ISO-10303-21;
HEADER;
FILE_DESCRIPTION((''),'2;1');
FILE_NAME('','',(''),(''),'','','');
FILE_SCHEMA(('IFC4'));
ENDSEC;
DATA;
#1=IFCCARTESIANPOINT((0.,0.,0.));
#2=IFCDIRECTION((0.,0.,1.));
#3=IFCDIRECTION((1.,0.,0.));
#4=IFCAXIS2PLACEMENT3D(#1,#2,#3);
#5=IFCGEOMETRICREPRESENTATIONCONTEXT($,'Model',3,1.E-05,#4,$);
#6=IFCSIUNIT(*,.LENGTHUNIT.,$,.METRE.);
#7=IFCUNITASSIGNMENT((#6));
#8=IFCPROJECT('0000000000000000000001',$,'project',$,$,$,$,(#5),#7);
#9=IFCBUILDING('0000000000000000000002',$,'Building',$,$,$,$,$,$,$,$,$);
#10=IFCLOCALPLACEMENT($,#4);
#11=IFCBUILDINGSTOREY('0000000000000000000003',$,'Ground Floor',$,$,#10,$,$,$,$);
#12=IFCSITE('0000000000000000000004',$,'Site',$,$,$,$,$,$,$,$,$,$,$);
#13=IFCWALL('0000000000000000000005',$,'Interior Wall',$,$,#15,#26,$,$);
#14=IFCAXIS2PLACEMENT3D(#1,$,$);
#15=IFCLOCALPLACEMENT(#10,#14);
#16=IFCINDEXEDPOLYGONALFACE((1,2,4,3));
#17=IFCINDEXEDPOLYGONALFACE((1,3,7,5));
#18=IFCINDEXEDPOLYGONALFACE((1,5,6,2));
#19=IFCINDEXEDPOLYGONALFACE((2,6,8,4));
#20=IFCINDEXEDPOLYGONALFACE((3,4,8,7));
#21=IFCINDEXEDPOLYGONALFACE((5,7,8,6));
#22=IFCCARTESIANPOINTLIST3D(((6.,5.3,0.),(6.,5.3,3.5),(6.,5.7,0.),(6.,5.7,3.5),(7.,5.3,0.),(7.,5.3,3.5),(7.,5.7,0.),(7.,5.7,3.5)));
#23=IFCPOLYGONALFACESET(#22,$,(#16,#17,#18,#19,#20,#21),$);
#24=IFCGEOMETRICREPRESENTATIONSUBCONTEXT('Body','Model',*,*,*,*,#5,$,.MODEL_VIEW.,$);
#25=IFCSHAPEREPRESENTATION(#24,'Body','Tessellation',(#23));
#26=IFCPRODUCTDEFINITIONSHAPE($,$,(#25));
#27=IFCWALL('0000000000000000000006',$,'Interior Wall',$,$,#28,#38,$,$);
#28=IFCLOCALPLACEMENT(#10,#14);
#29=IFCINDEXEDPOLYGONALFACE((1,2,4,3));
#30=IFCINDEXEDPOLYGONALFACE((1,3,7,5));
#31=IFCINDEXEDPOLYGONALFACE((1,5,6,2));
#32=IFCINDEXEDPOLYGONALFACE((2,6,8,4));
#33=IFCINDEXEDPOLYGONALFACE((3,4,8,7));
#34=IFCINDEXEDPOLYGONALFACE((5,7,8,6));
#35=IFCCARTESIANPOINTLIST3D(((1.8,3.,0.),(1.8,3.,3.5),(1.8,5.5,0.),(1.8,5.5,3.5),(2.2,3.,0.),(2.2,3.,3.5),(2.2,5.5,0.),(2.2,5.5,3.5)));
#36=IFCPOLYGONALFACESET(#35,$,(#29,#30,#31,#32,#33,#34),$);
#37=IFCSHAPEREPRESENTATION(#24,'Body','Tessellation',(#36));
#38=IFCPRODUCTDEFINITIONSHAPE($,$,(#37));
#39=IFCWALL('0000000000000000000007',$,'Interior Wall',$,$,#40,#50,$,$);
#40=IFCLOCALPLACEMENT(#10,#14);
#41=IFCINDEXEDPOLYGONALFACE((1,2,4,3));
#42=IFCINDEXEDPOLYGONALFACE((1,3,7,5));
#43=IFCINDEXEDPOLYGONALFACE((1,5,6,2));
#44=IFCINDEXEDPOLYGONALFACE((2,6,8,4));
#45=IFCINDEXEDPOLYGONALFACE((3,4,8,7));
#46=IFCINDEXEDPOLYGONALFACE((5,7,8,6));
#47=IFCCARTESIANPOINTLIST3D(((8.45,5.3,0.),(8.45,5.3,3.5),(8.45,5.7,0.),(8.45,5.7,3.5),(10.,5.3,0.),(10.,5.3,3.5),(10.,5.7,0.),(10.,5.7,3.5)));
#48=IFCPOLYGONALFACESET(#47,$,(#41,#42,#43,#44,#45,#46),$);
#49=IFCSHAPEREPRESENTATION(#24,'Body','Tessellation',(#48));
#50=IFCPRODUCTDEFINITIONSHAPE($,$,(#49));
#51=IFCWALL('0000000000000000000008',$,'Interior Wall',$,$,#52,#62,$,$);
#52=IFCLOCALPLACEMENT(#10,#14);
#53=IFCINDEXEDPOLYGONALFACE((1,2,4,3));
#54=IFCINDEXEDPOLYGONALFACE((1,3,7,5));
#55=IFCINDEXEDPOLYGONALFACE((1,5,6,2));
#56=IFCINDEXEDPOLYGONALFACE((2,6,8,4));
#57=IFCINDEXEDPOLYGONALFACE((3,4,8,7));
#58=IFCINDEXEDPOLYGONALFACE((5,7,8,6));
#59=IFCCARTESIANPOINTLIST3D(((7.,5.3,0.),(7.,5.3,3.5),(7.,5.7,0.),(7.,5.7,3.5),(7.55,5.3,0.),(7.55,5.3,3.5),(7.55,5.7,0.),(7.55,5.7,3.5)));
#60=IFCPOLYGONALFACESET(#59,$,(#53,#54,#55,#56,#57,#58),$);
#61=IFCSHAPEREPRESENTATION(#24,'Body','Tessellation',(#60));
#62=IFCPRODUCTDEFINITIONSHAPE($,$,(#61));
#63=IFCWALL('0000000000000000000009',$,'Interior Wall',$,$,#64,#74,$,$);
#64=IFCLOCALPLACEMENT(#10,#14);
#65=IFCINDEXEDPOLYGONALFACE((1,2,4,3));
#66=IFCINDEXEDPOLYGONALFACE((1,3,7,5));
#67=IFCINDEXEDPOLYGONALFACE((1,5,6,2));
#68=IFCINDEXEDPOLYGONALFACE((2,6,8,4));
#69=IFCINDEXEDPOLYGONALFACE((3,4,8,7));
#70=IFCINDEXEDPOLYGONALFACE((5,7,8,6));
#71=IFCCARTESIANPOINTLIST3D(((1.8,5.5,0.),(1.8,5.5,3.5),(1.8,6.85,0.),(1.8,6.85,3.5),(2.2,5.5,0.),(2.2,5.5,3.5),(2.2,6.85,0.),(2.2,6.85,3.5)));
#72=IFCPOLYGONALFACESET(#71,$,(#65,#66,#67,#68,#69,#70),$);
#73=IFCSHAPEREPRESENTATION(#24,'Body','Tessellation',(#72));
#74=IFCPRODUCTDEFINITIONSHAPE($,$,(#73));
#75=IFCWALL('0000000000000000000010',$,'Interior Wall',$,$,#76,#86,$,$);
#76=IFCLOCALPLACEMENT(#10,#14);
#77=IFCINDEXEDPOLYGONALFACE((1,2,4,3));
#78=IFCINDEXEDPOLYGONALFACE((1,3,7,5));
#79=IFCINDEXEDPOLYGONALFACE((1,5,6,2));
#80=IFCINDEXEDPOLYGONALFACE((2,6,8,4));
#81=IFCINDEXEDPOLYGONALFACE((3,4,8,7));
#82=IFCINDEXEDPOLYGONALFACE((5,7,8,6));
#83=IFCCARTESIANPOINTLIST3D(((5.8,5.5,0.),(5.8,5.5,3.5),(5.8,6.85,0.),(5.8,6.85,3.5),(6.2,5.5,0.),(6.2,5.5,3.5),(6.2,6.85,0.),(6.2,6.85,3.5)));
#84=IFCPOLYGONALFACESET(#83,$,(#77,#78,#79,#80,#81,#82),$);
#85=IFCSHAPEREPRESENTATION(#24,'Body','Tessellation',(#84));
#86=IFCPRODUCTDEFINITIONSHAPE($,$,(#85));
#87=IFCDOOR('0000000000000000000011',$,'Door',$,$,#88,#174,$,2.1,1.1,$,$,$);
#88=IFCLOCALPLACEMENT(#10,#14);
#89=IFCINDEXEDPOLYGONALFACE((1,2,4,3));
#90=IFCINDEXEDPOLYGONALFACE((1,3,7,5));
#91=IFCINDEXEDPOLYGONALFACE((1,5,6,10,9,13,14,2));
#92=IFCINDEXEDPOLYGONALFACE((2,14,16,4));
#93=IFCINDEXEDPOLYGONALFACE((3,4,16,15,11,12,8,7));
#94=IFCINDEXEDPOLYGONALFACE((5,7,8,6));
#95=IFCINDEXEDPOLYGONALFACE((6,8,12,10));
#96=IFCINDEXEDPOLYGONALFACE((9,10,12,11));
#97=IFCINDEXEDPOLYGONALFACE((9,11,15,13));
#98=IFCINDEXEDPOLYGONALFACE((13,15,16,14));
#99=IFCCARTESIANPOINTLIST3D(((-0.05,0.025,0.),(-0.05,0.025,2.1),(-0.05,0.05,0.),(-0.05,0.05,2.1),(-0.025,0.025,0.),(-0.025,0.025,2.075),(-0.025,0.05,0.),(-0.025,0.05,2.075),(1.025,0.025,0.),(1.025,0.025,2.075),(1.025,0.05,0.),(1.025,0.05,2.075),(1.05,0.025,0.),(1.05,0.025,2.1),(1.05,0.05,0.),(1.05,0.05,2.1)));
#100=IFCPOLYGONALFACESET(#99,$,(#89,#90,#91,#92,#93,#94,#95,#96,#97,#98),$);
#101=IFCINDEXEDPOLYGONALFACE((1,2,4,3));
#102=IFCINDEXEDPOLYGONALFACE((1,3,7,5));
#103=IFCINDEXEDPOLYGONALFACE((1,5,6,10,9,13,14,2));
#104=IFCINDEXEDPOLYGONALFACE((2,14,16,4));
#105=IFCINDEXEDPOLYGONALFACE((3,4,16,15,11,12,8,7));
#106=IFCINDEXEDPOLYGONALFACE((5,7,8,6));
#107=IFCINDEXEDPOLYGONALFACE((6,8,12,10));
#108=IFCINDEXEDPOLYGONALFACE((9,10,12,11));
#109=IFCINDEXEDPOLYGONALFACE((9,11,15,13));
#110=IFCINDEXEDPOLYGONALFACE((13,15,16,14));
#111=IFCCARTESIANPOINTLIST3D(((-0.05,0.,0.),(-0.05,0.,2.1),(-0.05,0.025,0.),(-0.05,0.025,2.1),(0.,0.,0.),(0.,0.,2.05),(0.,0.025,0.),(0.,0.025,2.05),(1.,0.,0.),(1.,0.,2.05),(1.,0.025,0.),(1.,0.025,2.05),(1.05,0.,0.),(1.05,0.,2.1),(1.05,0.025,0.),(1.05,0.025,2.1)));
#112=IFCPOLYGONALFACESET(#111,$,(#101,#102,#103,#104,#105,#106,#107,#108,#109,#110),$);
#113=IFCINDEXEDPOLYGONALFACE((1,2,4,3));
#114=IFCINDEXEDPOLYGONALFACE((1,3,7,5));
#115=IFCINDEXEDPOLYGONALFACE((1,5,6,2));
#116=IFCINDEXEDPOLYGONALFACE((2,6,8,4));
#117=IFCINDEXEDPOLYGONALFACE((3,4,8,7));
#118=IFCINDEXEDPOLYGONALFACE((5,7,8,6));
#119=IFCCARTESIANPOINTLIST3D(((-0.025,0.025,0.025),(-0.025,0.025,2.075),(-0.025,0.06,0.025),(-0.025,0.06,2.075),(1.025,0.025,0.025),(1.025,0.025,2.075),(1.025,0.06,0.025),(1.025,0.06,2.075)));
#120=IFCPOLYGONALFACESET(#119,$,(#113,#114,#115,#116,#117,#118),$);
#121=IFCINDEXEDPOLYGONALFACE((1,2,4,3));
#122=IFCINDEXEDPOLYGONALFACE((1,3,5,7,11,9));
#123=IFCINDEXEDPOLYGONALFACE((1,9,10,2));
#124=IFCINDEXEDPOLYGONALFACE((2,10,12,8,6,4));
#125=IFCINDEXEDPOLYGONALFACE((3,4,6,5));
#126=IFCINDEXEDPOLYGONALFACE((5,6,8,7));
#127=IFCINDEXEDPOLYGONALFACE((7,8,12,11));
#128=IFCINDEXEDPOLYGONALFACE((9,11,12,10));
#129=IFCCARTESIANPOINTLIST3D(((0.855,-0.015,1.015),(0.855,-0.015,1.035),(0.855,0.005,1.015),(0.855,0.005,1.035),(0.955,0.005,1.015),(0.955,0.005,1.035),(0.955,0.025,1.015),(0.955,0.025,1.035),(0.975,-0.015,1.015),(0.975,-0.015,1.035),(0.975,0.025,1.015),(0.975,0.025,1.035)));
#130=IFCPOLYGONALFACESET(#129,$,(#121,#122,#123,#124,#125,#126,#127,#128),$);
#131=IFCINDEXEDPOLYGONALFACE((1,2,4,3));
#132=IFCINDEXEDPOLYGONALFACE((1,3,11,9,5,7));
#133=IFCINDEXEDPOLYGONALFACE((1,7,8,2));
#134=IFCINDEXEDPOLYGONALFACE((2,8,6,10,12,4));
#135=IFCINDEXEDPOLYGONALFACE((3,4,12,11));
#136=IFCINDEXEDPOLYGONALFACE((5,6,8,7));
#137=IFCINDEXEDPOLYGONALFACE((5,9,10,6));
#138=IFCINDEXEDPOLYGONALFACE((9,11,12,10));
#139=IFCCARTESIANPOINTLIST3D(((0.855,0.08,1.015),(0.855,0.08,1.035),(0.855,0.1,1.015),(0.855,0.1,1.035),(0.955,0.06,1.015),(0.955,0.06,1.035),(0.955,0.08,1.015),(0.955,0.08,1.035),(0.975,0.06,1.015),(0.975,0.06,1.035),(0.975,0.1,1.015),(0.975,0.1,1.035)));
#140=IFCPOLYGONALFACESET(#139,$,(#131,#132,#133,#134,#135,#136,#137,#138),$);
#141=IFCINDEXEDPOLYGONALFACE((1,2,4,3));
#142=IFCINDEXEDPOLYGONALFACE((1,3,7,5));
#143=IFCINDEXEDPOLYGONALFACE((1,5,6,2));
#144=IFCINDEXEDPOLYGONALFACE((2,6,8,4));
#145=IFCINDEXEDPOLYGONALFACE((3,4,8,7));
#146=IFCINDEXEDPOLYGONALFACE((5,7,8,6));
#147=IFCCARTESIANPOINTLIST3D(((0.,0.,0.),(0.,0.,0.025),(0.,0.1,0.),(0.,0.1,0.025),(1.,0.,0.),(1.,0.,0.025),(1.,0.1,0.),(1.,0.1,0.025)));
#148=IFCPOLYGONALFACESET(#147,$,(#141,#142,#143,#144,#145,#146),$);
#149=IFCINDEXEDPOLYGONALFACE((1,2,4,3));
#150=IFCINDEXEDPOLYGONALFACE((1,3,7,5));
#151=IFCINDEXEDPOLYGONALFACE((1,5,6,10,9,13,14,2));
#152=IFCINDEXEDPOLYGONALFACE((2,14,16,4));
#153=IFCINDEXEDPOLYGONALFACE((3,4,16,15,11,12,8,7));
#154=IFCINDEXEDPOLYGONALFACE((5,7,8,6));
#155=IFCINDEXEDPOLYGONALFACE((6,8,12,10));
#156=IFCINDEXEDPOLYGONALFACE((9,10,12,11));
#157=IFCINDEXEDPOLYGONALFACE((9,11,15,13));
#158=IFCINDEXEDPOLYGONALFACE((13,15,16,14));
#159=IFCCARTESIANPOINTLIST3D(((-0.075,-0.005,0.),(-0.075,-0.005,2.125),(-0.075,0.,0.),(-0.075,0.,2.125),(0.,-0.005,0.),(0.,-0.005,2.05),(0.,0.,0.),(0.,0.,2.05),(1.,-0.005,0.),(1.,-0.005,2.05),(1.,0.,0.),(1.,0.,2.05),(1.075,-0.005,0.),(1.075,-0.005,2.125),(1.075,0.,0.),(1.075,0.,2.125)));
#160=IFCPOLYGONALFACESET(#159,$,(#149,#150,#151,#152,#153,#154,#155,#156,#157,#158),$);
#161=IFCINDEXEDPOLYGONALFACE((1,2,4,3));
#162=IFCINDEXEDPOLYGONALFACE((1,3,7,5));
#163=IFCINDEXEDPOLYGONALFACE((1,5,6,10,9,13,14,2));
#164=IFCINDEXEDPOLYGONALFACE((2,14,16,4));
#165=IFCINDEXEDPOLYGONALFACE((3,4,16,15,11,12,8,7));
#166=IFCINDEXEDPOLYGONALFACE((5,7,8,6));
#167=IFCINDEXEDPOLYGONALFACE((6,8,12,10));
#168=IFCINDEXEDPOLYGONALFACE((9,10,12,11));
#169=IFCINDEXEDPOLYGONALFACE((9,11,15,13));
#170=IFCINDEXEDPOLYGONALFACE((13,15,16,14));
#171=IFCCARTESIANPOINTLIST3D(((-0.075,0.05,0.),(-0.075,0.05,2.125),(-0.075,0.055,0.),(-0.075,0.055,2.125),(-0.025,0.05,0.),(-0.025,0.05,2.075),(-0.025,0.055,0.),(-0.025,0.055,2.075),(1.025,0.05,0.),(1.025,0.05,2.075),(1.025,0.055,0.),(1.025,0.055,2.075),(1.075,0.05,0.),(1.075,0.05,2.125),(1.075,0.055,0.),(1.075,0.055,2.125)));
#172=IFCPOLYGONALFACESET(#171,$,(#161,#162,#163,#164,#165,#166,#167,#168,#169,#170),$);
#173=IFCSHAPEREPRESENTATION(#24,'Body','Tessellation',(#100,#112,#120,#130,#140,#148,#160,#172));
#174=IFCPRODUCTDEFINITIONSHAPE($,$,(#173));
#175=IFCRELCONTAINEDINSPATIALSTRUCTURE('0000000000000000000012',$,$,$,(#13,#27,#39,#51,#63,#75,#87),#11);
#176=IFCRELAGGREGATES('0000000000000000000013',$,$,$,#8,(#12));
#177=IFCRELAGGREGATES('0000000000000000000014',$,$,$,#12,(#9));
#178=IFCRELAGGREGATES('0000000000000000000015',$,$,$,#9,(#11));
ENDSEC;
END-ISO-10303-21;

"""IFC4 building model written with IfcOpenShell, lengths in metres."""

from ifc_helpers import new_model, si_unit, frame, origin_with_axes, place, context, subcontext, project, spatial, line, indexed_curve, outline, extrude, element, save


model = new_model("IFC4")

# Units and contexts
model_context = context("Model", 3, precision=1e-05, world=origin_with_axes())
body_context = subcontext(model_context, "Body", "Model", "MODEL_VIEW")
ifc_project = project(units=[si_unit("LENGTHUNIT", "METRE")], contexts=[model_context])

# Site, building, storey
site = spatial("IfcSite", under=ifc_project, Name="Site")
building = spatial("IfcBuilding", under=site, Name="Building")
storey_placement = place(None, origin_with_axes())
storey = spatial("IfcBuildingStorey", under=building, at=storey_placement, Name="Ground Floor")

# Walls
wall_1_placement = place(storey_placement, frame((7.0, 5.5, 0.0), z_axis=(0.0, 0.0, 1.0), x_axis=(-1.0, 0.0, 0.0)))
element("IfcWall", 1, at=wall_1_placement, inside=storey, Name="Interior Wall", context=body_context, shape_type="SweptSolid", body=[
    extrude(outline(indexed_curve([(0.0, 0.0), (0.0, 0.4), (1.0, 0.4), (1.0, 0.0), (0.0, 0.0)], self_intersect=False)), frame((0.0, -0.2, 0.0), z_axis=(0.0, 0.0, 1.0), x_axis=(1.0, 0.0, 0.0)), (0.0, 0.0, 1.0), 3.5),
])
wall_2_placement = place(storey_placement, frame((2.0, 5.5, 0.0), z_axis=(0.0, 0.0, 1.0), x_axis=(0.0, -1.0, 0.0)))
element("IfcWall", 2, at=wall_2_placement, inside=storey, Name="Interior Wall", context=body_context, shape_type="SweptSolid", body=[
    extrude(outline(indexed_curve([(0.0, 0.0), (0.0, 0.4), (2.5, 0.4), (2.5, 0.0), (0.0, 0.0)], self_intersect=False)), frame((0.0, -0.2, 0.0), z_axis=(0.0, 0.0, 1.0), x_axis=(1.0, 0.0, 0.0)), (0.0, 0.0, 1.0), 3.5),
])
wall_3_placement = place(storey_placement, frame((10.0, 5.5, 0.0), z_axis=(0.0, 0.0, 1.0), x_axis=(-1.0, 0.0, 0.0)))
element("IfcWall", 3, at=wall_3_placement, inside=storey, Name="Interior Wall", context=body_context, shape_type="SweptSolid", body=[
    extrude(outline(indexed_curve([(0.0, 0.0), (0.0, 0.4), (1.55, 0.4), (1.55, 0.0), (0.0, 0.0)], self_intersect=False)), frame((0.0, -0.2, 0.0), z_axis=(0.0, 0.0, 1.0), x_axis=(1.0, 0.0, 0.0)), (0.0, 0.0, 1.0), 3.5),
])
wall_4_placement = place(storey_placement, frame((7.55, 5.5, 0.0), z_axis=(0.0, 0.0, 1.0), x_axis=(-1.0, 0.0, 0.0)))
element("IfcWall", 4, at=wall_4_placement, inside=storey, Name="Interior Wall", context=body_context, shape_type="SweptSolid", body=[
    extrude(outline(indexed_curve([(0.0, 0.0), (0.0, 0.4), (0.55, 0.4), (0.55, 0.0), (0.0, 0.0)], self_intersect=False)), frame((0.0, -0.2, 0.0), z_axis=(0.0, 0.0, 1.0), x_axis=(1.0, 0.0, 0.0)), (0.0, 0.0, 1.0), 3.5),
])
for number, where, z_axis, x_axis, name in (
    (5, (2.0, 5.5, 0.0), (0.0, 0.0, 1.0), (0.0, 1.0, 0.0), "Interior Wall"),
    (6, (6.0, 5.5, 0.0), (0.0, 0.0, 1.0), (0.0, 1.0, 0.0), "Interior Wall"),
):
    element("IfcWall", number, at=place(storey_placement, frame(where, z_axis=z_axis, x_axis=x_axis)), inside=storey, Name=name, context=body_context, shape_type="SweptSolid", body=[
        extrude(outline(indexed_curve([(0.0, 0.0), (0.0, 0.4), (1.35, 0.4), (1.35, 0.0), (0.0, 0.0)], self_intersect=False)), frame((0.0, -0.2, 0.0), z_axis=(0.0, 0.0, 1.0), x_axis=(1.0, 0.0, 0.0)), (0.0, 0.0, 1.0), 3.5),
    ])

# Door
door_1_placement = place(storey_placement, frame((-0.05, 0.0, 0.0), z_axis=(0.0, 0.0, 1.0), x_axis=(1.0, 0.0, 0.0)))
element("IfcDoor", 7, at=door_1_placement, inside=storey, Name="Door", OverallHeight=2.1, OverallWidth=1.1, context=body_context, shape_type="SweptSolid", body=[
    extrude(outline(indexed_curve([(0.0, 0.0), (0.0, 2.1), (1.1, 2.1), (1.1, 0.0), (1.075, 0.0), (1.075, 2.075), (0.025, 2.075), (0.025, 0.0)], segments=[line(1, 2, 3, 4, 5, 6, 7, 8, 1)])), frame((0.0, 0.025, 0.0), z_axis=(0.0, -1.0, 0.0), x_axis=(1.0, 0.0, 0.0)), (0.0, 0.0, -1.0), 0.025),
    extrude(outline(indexed_curve([(0.0, 0.0), (0.0, 2.1), (1.1, 2.1), (1.1, 0.0), (1.05, 0.0), (1.05, 2.05), (0.05, 2.05), (0.05, 0.0)], segments=[line(1, 2, 3, 4, 5, 6, 7, 8, 1)])), frame((0.0, 0.0, 0.0), z_axis=(0.0, -1.0, 0.0), x_axis=(1.0, 0.0, 0.0)), (0.0, 0.0, -1.0), 0.025),
    extrude(outline(indexed_curve([(0.0, 0.0), (1.05, 0.0), (1.05, 0.035), (0.0, 0.035)], segments=[line(1, 2, 3, 4, 1)])), frame((0.025, 0.025, 0.025), z_axis=(0.0, 0.0, 1.0), x_axis=(1.0, 0.0, 0.0)), (0.0, 0.0, 1.0), 2.05),
    extrude(outline(indexed_curve([(0.0, 0.0), (0.0, -0.04), (-0.12, -0.04), (-0.12, -0.02), (-0.02, -0.02), (-0.02, 0.0)], segments=[line(1, 2, 3, 4, 5, 6, 1)])), frame((1.025, 0.025, 1.015), z_axis=(0.0, 0.0, 1.0), x_axis=(1.0, 0.0, 0.0)), (0.0, 0.0, 1.0), 0.02),
    extrude(outline(indexed_curve([(0.0, 0.0), (0.0, 0.04), (-0.12, 0.04), (-0.12, 0.02), (-0.02, 0.02), (-0.02, 0.0)], segments=[line(1, 2, 3, 4, 5, 6, 1)])), frame((1.025, 0.06, 1.015), z_axis=(0.0, 0.0, 1.0), x_axis=(1.0, 0.0, 0.0)), (0.0, 0.0, 1.0), 0.02),
    extrude(outline(indexed_curve([(0.0, 0.0), (1.0, 0.0), (1.0, 0.1), (0.0, 0.1)], segments=[line(1, 2, 3, 4, 1)])), frame((0.05, 0.0, 0.0), z_axis=(0.0, 0.0, 1.0), x_axis=(1.0, 0.0, 0.0)), (0.0, 0.0, 1.0), 0.025),
    extrude(outline(indexed_curve([(0.0, 0.0), (0.0, 2.125), (1.15, 2.125), (1.15, 0.0), (1.075, 0.0), (1.075, 2.05), (0.075, 2.05), (0.075, 0.0)], segments=[line(1, 2, 3, 4, 5, 6, 7, 8, 1)])), frame((-0.025, -0.005, 0.0), z_axis=(0.0, -1.0, 0.0), x_axis=(1.0, 0.0, 0.0)), (0.0, 0.0, -1.0), 0.005),
    extrude(outline(indexed_curve([(0.0, 0.0), (0.0, 2.125), (1.15, 2.125), (1.15, 0.0), (1.1, 0.0), (1.1, 2.075), (0.05, 2.075), (0.05, 0.0)], segments=[line(1, 2, 3, 4, 5, 6, 7, 8, 1)])), frame((-0.025, 0.05, 0.0), z_axis=(0.0, -1.0, 0.0), x_axis=(1.0, 0.0, 0.0)), (0.0, 0.0, -1.0), 0.005),
])

save(model, "model.ifc")
